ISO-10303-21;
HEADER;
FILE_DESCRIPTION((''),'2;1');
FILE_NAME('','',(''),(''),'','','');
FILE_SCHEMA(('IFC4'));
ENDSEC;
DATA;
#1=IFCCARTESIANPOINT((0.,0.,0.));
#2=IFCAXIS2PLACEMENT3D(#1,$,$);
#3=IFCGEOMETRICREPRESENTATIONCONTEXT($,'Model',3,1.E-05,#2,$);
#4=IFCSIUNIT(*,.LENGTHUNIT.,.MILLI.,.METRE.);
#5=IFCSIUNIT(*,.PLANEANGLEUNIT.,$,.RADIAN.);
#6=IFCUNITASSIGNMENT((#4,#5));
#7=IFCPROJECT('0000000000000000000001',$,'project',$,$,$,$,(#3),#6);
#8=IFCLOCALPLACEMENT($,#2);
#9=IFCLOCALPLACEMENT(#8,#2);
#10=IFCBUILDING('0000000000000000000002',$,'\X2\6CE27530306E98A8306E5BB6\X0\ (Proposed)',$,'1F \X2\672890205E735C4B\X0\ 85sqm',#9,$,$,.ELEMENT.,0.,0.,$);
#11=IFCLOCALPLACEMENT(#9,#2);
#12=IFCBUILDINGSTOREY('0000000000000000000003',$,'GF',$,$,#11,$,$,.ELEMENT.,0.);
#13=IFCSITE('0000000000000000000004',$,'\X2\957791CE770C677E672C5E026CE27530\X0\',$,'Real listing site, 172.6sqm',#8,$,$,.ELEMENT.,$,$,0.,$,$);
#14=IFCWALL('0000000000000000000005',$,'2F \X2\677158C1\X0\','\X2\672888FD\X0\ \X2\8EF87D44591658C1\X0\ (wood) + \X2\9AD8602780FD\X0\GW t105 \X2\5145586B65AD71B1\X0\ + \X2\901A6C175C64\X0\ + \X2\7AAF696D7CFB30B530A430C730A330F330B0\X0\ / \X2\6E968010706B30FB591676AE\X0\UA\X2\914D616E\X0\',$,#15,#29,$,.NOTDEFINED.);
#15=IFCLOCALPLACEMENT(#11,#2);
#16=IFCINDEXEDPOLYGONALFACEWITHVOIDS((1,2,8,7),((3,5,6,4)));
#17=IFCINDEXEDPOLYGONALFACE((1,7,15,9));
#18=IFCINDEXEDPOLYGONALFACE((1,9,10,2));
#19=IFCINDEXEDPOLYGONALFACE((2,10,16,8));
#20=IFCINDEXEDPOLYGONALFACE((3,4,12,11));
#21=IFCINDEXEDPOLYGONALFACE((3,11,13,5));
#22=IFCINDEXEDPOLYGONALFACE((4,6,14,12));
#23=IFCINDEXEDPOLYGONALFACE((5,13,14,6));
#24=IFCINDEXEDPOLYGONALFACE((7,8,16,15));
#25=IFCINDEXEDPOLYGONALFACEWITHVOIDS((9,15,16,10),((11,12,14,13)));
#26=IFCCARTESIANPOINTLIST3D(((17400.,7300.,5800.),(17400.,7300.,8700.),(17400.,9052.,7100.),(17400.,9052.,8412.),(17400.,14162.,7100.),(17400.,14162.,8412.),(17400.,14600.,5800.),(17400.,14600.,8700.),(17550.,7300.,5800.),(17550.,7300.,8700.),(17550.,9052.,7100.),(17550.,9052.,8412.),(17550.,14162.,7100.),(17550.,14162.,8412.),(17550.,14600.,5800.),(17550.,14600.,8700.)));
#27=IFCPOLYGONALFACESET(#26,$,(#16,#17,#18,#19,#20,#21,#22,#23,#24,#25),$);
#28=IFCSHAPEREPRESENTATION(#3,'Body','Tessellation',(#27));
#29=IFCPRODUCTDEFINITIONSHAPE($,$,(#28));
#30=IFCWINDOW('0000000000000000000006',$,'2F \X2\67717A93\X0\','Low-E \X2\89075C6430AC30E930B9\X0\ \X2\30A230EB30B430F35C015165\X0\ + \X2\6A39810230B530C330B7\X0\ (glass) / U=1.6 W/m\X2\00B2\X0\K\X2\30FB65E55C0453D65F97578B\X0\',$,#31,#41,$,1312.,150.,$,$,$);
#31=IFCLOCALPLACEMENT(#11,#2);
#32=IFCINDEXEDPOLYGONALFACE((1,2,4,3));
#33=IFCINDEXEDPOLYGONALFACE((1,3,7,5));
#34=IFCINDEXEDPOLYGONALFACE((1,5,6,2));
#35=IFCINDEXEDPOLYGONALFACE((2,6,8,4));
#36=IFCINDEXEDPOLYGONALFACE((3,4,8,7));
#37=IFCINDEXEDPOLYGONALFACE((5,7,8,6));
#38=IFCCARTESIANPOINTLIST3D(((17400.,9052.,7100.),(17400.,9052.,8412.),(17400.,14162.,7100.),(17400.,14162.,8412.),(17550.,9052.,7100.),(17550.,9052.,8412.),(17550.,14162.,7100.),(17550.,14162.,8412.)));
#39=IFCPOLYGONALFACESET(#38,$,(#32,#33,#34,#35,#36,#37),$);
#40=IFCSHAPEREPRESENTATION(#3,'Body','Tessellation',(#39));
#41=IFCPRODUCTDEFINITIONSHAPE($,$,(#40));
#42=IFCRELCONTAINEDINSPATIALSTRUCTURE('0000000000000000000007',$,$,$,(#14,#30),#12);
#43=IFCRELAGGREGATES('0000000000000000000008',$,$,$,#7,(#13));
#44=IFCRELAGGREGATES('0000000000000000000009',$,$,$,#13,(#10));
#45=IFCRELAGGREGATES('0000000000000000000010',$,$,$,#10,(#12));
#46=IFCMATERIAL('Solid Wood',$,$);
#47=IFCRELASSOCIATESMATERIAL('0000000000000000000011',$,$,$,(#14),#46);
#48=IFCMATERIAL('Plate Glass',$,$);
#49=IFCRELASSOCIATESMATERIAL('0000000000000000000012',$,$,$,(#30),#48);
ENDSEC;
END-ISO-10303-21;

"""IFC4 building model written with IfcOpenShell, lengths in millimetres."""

from ifc_helpers import new_model, si_unit, frame, frame_2d, origin, place, context, project, spatial, rectangle, extrude, material, element, fill, save


model = new_model("IFC4")

# Units and contexts
model_context = context("Model", 3, precision=1e-05, world=origin())
ifc_project = project(units=[si_unit("LENGTHUNIT", "METRE", prefix="MILLI"), si_unit("PLANEANGLEUNIT", "RADIAN")], contexts=[model_context])

# Site, building, storey
site_placement = place(None, origin())
site = spatial("IfcSite", under=ifc_project, at=site_placement, Name="長野県松本市波田", ObjectType="Real listing site, 172.6sqm", CompositionType="ELEMENT", RefElevation=0.0)
building_placement = place(site_placement, origin())
building = spatial("IfcBuilding", under=site, at=building_placement, Name="波田の風の家 (Proposed)", ObjectType="1F 木造平屋 85sqm", CompositionType="ELEMENT", ElevationOfRefHeight=0.0, ElevationOfTerrain=0.0)
storey_placement = place(building_placement, origin())
storey = spatial("IfcBuildingStorey", under=building, at=storey_placement, Name="GF", CompositionType="ELEMENT", Elevation=0.0)

# Shared definitions
ifc_material_1 = material(Name="Solid Wood")

# Shared definitions
ifc_material_2 = material(Name="Plate Glass")

# Wall, opening, window
wall_1_placement = place(storey_placement, frame((8700.0, 3650.0, 2900.0)))
wall_1 = element("IfcWall", 1, at=wall_1_placement, inside=storey, material=ifc_material_1, Name="2F 東壁", Description="木製 軸組外壁 (wood) + 高性能GW t105 充填断熱 + 通気層 + 窯業系サイディング / 準耐火・外皮UA配慮", PredefinedType="NOTDEFINED", context=model_context, shape_type="SweptSolid", body=[
    extrude(rectangle(XDim=150.0, YDim=7300.0, at=frame_2d((75.0, 3650.0))), frame((8700.0, 3650.0, 2900.0)), (0.0, 0.0, 1.0), 2900.0),
])
opening_1_placement = place(storey_placement, frame((8700.0, 4526.0, 3550.0)))
opening_1 = element("IfcOpeningElement", 2, at=opening_1_placement, cuts=wall_1, PredefinedType="NOTDEFINED", context=model_context, shape_type="SweptSolid", body=[
    extrude(rectangle(XDim=150.0, YDim=5110.0, at=frame_2d((75.0, 2555.0))), frame((8700.0, 4526.0, 3550.0)), (0.0, 0.0, 1.0), 1312.0),
])
window_1_placement = place(storey_placement, frame((8700.0, 4526.0, 3550.0)))
window_1 = element("IfcWindow", 3, at=window_1_placement, inside=storey, material=ifc_material_2, Name="2F 東窓", Description="Low-E 複層ガラス アルゴン封入 + 樹脂サッシ (glass) / U=1.6 W/m²K・日射取得型", OverallHeight=1312.0, OverallWidth=150.0, context=model_context, shape_type="SweptSolid", body=[
    extrude(rectangle(XDim=150.0, YDim=5110.0, at=frame_2d((75.0, 2555.0))), frame((8700.0, 4526.0, 3550.0)), (0.0, 0.0, 1.0), 1312.0),
])
fill(opening_1, window_1)

save(model, "model.ifc")
